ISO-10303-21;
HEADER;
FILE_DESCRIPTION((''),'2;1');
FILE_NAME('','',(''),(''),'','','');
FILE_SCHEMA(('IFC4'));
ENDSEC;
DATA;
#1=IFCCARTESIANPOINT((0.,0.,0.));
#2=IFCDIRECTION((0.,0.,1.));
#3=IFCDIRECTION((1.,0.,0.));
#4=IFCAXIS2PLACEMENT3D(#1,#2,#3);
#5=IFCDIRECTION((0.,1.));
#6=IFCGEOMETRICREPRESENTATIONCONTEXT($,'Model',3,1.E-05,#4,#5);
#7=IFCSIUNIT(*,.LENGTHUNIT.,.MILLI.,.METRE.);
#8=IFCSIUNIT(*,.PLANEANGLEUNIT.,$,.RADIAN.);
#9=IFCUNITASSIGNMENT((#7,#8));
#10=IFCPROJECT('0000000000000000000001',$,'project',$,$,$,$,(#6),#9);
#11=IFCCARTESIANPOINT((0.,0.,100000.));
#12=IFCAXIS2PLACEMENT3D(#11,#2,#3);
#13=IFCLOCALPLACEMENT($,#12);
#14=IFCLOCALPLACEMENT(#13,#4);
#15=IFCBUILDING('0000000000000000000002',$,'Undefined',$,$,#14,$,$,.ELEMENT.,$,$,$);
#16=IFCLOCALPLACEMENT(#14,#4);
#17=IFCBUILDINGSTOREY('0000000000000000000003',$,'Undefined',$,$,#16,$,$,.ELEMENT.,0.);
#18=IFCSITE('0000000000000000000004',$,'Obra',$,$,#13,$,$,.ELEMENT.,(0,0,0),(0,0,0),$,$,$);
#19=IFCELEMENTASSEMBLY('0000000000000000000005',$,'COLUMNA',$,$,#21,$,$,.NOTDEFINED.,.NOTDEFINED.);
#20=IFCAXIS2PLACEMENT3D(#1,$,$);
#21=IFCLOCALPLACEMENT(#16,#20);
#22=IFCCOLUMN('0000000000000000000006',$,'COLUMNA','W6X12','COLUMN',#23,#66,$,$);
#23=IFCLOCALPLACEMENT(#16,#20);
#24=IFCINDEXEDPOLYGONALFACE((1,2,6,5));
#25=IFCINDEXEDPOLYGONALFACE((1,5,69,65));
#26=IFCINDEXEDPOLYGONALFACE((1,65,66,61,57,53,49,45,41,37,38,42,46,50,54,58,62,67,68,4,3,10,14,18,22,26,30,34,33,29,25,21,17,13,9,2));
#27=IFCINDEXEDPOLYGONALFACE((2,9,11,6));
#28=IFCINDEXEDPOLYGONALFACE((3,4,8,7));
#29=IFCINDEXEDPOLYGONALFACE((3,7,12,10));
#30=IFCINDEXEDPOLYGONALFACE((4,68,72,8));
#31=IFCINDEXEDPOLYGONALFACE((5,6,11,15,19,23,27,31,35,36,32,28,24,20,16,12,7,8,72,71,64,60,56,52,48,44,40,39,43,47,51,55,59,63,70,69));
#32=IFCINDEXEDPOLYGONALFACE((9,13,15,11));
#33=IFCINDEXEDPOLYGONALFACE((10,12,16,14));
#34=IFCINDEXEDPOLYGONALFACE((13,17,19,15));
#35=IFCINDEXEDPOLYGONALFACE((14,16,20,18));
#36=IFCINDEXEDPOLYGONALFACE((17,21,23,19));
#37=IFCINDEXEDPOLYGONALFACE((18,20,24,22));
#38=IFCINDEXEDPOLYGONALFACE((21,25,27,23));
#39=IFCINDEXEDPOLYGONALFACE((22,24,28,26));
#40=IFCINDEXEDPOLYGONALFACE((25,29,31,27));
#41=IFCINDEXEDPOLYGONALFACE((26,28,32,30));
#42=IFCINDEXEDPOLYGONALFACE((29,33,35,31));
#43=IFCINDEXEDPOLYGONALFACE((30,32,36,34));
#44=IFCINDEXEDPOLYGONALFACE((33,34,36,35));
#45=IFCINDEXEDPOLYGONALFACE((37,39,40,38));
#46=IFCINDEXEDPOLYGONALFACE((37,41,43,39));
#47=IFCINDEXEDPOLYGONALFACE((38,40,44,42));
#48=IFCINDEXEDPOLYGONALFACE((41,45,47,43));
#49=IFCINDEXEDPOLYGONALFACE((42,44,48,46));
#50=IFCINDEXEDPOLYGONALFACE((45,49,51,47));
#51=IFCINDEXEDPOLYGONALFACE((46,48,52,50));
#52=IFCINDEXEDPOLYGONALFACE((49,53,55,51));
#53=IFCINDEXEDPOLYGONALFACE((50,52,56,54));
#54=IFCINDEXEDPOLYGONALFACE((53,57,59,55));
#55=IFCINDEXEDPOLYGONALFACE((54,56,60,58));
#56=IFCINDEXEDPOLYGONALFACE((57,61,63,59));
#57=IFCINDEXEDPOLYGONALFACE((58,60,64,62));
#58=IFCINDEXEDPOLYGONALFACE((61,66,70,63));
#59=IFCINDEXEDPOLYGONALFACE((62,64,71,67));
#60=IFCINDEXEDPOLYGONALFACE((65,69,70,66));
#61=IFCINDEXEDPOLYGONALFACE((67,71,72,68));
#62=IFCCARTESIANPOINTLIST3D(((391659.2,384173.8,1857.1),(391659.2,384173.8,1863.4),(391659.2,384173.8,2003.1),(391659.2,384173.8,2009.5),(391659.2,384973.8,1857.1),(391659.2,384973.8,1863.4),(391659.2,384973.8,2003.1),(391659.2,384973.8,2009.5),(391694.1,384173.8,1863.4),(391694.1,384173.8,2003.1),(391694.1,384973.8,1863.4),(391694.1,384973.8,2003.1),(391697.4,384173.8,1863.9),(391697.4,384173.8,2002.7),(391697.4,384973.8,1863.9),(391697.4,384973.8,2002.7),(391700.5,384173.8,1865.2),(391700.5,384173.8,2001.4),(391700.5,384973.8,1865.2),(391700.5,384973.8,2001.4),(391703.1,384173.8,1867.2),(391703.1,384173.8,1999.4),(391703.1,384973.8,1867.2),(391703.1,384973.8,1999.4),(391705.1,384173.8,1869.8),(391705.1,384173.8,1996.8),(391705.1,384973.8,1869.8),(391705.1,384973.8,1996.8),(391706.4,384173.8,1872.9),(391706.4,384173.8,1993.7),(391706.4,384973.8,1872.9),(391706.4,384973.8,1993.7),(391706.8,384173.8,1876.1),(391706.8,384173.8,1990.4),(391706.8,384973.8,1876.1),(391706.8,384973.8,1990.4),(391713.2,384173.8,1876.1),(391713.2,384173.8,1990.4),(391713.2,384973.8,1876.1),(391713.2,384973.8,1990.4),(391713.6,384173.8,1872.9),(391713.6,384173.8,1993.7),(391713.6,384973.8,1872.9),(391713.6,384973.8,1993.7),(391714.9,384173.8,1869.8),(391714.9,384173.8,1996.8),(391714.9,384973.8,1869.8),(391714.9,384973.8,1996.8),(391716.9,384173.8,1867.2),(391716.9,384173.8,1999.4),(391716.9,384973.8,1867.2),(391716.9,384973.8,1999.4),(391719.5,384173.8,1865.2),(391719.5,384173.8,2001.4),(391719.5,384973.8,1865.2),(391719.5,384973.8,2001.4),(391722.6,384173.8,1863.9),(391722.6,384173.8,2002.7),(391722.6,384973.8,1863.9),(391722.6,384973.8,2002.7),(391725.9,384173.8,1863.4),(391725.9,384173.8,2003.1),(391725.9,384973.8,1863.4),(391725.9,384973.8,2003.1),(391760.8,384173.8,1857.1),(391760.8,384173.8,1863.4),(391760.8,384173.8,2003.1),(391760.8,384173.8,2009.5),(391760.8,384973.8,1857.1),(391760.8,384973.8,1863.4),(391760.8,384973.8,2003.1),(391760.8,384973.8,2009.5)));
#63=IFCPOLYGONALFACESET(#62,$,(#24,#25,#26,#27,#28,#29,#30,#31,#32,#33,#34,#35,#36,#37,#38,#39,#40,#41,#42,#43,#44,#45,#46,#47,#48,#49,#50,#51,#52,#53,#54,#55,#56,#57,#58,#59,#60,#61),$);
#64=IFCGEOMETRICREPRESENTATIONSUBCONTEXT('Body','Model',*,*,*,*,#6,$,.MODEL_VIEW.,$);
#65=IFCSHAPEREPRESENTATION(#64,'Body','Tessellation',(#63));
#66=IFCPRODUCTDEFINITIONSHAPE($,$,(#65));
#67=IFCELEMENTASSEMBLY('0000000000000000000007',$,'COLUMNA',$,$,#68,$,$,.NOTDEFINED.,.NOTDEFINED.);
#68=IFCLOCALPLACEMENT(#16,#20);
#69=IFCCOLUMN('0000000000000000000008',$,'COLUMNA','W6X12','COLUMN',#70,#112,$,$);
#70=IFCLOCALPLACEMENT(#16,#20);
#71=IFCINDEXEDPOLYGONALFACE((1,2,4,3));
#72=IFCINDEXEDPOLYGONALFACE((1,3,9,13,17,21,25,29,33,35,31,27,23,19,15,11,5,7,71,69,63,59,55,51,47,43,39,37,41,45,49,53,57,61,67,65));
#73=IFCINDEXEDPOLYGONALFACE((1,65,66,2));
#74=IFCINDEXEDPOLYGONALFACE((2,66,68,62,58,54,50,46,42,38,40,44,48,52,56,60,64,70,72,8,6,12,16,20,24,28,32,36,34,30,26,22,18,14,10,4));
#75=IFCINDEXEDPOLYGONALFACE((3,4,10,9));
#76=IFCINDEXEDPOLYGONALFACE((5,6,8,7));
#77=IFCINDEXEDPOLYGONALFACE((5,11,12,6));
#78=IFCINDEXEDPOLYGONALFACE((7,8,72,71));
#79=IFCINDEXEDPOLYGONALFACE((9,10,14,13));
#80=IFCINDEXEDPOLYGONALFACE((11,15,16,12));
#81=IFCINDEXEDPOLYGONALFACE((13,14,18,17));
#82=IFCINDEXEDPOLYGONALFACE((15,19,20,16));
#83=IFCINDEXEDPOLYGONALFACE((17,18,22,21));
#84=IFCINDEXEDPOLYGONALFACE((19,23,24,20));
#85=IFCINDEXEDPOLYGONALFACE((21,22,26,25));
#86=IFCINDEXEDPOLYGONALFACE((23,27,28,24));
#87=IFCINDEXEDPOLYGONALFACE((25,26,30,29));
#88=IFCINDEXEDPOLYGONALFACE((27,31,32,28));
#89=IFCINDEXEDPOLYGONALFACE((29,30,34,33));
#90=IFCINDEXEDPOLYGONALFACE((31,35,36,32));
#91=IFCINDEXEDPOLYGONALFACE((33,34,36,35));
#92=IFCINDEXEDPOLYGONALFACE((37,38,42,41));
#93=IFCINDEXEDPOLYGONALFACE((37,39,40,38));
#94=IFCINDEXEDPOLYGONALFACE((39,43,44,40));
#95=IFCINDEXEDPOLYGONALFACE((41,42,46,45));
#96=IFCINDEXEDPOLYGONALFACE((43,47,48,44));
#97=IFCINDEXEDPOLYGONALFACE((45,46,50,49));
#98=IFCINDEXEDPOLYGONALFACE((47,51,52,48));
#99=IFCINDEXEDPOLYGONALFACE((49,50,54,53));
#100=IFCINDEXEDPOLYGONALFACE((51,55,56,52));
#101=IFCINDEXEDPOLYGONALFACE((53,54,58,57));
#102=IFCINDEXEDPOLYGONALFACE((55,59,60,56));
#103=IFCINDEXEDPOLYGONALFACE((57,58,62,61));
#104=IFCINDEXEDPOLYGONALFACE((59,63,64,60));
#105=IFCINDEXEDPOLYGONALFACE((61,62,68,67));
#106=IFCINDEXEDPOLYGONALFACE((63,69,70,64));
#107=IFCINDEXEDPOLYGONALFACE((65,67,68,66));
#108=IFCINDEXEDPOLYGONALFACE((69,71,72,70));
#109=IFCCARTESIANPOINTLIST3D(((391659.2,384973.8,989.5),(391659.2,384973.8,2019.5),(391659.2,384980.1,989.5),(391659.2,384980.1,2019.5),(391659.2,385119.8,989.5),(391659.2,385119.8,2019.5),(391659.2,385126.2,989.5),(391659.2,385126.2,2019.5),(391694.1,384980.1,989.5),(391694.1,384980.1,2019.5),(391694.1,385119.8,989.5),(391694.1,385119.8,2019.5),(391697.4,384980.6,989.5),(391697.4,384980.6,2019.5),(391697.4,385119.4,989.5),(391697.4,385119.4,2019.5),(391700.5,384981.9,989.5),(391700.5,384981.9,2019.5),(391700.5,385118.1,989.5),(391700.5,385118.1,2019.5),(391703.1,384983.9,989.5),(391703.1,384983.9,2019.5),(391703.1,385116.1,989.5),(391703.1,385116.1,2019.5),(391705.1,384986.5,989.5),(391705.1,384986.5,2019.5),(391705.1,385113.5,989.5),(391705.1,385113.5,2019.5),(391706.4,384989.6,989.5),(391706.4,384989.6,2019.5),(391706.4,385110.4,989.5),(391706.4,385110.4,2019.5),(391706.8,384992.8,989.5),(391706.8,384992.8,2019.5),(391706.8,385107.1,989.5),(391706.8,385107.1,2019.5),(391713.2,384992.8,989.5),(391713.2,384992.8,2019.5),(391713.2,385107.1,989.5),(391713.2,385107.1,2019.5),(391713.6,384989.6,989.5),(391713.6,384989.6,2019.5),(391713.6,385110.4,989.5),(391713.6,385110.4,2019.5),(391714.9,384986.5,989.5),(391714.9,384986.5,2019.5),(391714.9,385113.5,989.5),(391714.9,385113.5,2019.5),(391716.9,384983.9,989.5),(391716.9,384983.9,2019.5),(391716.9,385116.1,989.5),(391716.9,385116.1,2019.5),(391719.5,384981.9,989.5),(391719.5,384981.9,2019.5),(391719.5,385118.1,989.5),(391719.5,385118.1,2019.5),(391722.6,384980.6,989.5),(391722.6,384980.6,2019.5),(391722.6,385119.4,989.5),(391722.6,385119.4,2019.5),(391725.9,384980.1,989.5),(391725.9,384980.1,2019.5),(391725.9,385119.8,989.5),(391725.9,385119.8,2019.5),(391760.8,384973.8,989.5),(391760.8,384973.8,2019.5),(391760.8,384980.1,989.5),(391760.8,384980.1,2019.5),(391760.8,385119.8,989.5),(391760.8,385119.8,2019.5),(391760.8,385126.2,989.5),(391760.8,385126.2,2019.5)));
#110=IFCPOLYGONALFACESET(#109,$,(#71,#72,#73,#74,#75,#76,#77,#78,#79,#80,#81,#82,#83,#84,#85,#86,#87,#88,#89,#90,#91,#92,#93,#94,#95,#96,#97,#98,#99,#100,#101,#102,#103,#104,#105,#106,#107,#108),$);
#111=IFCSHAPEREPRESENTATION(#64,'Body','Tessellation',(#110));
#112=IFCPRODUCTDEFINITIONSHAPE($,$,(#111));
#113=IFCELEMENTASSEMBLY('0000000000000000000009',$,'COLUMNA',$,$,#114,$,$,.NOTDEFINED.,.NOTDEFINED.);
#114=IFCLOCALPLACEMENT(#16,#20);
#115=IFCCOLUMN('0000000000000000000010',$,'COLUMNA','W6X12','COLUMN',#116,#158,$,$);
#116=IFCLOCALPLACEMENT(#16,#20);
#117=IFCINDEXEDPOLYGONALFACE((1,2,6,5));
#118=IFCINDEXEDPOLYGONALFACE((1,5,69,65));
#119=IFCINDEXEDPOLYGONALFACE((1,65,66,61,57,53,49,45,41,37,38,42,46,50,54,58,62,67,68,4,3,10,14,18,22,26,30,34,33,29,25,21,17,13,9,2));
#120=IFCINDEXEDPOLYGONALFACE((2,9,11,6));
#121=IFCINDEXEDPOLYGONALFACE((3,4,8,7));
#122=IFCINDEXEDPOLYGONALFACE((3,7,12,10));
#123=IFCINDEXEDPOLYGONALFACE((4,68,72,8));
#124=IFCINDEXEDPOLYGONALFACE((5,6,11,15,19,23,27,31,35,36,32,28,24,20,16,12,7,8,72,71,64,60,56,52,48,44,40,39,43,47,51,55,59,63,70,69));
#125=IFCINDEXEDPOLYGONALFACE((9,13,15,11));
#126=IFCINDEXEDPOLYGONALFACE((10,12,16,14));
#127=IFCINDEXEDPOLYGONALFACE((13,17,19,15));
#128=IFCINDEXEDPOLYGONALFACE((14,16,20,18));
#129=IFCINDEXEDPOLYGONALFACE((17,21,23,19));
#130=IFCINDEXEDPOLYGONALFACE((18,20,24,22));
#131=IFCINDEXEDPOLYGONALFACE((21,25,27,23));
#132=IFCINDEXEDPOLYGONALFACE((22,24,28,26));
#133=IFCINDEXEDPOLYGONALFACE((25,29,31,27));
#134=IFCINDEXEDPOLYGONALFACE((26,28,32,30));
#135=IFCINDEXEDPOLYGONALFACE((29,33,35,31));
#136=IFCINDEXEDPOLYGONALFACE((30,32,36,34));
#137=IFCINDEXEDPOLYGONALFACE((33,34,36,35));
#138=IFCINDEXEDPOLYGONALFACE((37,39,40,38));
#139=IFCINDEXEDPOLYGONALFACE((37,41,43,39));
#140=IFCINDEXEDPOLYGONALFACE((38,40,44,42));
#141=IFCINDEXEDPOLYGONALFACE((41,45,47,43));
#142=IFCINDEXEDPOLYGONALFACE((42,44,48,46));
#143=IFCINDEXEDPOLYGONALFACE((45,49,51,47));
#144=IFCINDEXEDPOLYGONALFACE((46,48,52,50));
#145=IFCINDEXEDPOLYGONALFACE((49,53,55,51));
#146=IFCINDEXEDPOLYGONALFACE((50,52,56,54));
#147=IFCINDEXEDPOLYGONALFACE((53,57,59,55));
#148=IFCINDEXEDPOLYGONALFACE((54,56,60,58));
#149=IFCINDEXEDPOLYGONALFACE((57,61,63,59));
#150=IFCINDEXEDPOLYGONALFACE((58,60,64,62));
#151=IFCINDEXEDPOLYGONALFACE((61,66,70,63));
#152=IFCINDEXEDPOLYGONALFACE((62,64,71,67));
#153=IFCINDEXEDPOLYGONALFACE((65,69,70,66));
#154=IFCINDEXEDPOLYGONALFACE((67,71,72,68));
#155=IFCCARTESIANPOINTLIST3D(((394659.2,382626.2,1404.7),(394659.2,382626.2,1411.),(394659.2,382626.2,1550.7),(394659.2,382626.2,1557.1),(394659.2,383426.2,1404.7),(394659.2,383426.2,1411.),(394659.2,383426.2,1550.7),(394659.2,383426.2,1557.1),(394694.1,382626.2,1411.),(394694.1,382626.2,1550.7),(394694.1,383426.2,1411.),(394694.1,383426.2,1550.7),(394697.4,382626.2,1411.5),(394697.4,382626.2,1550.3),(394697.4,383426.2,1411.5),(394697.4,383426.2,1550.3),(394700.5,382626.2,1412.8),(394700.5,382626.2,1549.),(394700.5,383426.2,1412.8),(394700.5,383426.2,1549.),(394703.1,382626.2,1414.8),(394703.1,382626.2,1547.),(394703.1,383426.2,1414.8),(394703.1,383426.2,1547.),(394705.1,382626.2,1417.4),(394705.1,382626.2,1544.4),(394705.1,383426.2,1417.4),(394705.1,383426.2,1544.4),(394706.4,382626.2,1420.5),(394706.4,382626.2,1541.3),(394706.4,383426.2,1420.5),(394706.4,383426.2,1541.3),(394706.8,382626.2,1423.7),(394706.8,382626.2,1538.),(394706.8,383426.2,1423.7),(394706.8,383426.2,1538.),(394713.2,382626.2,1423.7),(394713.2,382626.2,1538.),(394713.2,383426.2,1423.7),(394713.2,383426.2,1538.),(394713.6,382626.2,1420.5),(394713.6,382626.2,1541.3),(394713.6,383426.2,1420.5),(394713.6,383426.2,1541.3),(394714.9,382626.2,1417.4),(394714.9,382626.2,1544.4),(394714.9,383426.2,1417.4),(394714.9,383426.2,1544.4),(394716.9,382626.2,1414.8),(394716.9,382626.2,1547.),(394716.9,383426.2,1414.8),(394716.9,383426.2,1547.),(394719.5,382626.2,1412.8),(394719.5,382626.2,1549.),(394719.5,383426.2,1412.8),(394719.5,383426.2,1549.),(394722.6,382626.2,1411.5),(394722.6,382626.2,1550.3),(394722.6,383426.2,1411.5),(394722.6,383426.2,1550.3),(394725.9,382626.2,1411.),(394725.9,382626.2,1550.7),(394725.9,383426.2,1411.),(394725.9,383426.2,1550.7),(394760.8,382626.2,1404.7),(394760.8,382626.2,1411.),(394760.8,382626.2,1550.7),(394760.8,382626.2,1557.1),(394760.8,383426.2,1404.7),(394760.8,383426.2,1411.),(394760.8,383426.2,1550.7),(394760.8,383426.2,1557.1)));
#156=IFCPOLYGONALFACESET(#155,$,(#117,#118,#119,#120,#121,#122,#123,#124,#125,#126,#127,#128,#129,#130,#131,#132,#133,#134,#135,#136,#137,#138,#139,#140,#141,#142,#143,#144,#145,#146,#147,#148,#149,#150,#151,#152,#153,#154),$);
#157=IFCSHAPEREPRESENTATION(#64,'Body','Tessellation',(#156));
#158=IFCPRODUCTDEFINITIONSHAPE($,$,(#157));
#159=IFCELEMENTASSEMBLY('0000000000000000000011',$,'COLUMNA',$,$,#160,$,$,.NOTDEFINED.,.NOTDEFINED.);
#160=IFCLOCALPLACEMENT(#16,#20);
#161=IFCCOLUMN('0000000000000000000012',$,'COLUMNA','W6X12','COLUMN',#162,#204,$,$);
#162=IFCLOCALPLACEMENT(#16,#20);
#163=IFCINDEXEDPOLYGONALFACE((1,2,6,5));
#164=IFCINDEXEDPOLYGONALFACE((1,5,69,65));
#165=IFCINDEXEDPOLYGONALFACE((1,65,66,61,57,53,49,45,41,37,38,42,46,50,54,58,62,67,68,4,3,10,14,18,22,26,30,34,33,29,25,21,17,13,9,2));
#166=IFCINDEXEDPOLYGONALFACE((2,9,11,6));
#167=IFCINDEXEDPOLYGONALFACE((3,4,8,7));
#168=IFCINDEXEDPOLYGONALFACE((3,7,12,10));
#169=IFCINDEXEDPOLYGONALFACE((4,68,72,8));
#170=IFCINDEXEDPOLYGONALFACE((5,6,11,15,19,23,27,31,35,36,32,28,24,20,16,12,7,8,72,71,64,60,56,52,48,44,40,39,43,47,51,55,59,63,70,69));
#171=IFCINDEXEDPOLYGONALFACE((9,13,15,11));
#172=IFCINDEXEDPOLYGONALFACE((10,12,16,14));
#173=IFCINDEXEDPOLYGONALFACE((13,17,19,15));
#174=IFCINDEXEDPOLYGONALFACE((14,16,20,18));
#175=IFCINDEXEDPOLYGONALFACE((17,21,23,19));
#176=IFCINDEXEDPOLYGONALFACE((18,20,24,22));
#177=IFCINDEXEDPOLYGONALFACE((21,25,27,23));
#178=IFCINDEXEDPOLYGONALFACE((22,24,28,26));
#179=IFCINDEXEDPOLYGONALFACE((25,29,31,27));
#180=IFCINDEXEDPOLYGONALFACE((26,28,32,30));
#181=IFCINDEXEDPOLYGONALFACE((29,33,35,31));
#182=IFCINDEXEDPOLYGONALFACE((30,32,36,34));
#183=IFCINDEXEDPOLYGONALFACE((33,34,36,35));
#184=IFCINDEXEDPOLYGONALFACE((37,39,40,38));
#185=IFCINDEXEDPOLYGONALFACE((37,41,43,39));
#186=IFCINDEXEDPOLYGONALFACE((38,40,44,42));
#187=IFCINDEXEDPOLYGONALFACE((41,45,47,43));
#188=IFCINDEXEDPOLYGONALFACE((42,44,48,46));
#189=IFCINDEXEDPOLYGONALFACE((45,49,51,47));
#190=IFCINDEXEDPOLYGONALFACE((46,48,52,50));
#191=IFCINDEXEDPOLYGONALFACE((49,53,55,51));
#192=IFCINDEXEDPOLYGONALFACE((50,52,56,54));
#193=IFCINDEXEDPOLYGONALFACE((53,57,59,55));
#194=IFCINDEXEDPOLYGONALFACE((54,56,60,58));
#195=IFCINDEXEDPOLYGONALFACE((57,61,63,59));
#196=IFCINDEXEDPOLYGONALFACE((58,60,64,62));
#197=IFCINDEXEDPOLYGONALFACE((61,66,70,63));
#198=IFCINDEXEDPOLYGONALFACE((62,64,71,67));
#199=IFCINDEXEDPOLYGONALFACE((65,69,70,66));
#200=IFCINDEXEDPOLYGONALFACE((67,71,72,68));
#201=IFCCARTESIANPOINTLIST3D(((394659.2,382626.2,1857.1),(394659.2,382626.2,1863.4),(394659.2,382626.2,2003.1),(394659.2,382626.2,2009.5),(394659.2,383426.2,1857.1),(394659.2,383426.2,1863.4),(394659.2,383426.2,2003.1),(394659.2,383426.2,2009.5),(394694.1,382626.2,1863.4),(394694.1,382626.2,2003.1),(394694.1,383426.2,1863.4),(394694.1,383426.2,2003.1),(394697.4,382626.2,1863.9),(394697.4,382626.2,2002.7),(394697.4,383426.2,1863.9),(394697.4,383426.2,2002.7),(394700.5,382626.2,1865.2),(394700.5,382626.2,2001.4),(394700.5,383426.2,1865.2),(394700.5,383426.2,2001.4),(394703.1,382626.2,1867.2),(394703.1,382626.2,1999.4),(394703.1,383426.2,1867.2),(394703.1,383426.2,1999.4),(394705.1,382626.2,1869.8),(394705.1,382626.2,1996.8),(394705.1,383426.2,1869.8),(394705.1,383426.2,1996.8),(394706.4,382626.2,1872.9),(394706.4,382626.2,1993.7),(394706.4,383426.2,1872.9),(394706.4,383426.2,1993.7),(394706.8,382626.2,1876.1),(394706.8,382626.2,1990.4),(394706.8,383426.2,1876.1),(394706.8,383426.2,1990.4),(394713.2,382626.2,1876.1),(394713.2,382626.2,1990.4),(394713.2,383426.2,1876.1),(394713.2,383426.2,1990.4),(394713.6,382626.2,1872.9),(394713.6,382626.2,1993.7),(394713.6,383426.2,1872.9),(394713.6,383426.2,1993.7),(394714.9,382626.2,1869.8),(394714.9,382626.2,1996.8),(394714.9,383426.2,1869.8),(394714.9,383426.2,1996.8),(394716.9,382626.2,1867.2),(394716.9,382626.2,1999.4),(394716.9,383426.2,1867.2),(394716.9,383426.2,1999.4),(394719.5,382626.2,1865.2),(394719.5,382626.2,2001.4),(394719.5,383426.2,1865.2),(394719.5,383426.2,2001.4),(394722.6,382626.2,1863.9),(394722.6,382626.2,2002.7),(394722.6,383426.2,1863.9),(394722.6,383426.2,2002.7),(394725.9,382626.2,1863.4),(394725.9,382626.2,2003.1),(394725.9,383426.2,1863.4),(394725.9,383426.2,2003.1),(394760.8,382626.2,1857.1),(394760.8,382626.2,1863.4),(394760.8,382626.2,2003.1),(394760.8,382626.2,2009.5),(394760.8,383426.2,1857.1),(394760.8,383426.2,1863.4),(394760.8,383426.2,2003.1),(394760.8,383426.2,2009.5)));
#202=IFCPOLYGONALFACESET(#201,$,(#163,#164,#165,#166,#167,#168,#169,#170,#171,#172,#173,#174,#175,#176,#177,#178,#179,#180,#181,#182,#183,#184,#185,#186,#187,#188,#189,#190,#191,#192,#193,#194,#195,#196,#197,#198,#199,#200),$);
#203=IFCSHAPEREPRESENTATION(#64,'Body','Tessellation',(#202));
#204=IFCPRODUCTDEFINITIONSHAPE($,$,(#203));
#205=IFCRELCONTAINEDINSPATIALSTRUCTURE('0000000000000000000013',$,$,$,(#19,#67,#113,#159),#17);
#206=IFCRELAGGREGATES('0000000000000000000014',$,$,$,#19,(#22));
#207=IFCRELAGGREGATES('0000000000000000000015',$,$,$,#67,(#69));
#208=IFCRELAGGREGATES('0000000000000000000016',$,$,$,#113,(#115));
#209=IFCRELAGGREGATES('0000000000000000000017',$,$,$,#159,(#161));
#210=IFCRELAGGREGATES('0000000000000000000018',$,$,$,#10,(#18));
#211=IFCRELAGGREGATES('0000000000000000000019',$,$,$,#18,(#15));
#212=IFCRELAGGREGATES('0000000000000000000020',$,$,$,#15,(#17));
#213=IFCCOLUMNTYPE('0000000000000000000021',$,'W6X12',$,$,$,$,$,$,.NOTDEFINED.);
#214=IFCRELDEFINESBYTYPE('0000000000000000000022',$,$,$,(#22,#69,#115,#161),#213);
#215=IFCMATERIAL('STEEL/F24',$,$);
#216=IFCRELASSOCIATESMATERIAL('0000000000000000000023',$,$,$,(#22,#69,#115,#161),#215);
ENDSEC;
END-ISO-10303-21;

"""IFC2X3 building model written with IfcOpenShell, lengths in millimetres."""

from ifc_helpers import new_model, si_unit, direction, frame, origin_with_axes, origin_2d_with_axis, place, context, subcontext, project, spatial, i_section, extrude, material, type_object, element, aggregate, save


model = new_model("IFC2X3")

# Units and contexts
model_context = context("Model", 3, precision=1e-05, world=origin_with_axes(), true_north=direction((0.0, 1.0)))
body_context = subcontext(model_context, "Body", "Model", "MODEL_VIEW")
ifc_project = project(units=[si_unit("LENGTHUNIT", "METRE", prefix="MILLI"), si_unit("PLANEANGLEUNIT", "RADIAN")], contexts=[model_context])

# Site, building, storey
site_placement = place(None, frame((0.0, 0.0, 100000.0), z_axis=(0.0, 0.0, 1.0), x_axis=(1.0, 0.0, 0.0)))
site = spatial("IfcSite", under=ifc_project, at=site_placement, Name="Obra", CompositionType="ELEMENT", RefLatitude=(0, 0, 0), RefLongitude=(0, 0, 0))
building_placement = place(site_placement, origin_with_axes())
building = spatial("IfcBuilding", under=site, at=building_placement, Name="Undefined", CompositionType="ELEMENT")
storey_placement = place(building_placement, origin_with_axes())
storey = spatial("IfcBuildingStorey", under=building, at=storey_placement, Name="Undefined", CompositionType="ELEMENT", Elevation=0.0)

# Element assemblies, columns
ifc_material_1 = material(Name="STEEL/F24")
column_type_1 = type_object("IfcColumnType", Name="W6X12", PredefinedType="NOTDEFINED")
assembly_1_placement = place(storey_placement, origin_with_axes())
assembly_1 = element("IfcElementAssembly", 1, at=assembly_1_placement, inside=storey, Name="COLUMNA", AssemblyPlace="NOTDEFINED", PredefinedType="NOTDEFINED")
column_1_placement = place(assembly_1_placement, frame((391710.0, 384973.8, 1933.3), z_axis=(0.0, -1.0, 0.0), x_axis=(0.0, 0.0, -1.0)))
column_1 = element("IfcColumn", 2, at=column_1_placement, type_object=column_type_1, material=ifc_material_1, Name="COLUMNA", Description="W6X12", ObjectType="COLUMN", context=body_context, shape_type="SweptSolid", body=[
    extrude(i_section(OverallWidth=101.6, OverallDepth=152.4, WebThickness=6.3, FlangeThickness=6.3, FilletRadius=12.7, at=origin_2d_with_axis()), frame((0.0, 0.0, 800.0), z_axis=(0.0, 0.0, -1.0), x_axis=(0.0, 1.0, 0.0)), (0.0, 0.0, 1.0), 800.0),
])
aggregate(assembly_1, [column_1])
assembly_2_placement = place(storey_placement, origin_with_axes())
assembly_2 = element("IfcElementAssembly", 3, at=assembly_2_placement, inside=storey, Name="COLUMNA", AssemblyPlace="NOTDEFINED", PredefinedType="NOTDEFINED")
column_2_placement = place(assembly_2_placement, frame((391710.0, 385050.0, 989.5), z_axis=(0.0, 0.0, 1.0), x_axis=(0.0, 1.0, 0.0)))
column_2 = element("IfcColumn", 4, at=column_2_placement, type_object=column_type_1, material=ifc_material_1, Name="COLUMNA", Description="W6X12", ObjectType="COLUMN", context=body_context, shape_type="SweptSolid", body=[
    extrude(i_section(OverallWidth=101.6, OverallDepth=152.4, WebThickness=6.3, FlangeThickness=6.3, FilletRadius=12.7, at=origin_2d_with_axis()), frame((0.0, 0.0, 1030.0), z_axis=(0.0, 0.0, -1.0), x_axis=(0.0, 1.0, 0.0)), (0.0, 0.0, 1.0), 1030.0),
])
aggregate(assembly_2, [column_2])
assembly_3_placement = place(storey_placement, origin_with_axes())
assembly_3 = element("IfcElementAssembly", 5, at=assembly_3_placement, inside=storey, Name="COLUMNA", AssemblyPlace="NOTDEFINED", PredefinedType="NOTDEFINED")
column_3_placement = place(assembly_3_placement, frame((394710.0, 382626.2, 1480.9), z_axis=(0.0, 1.0, 0.0), x_axis=(0.0, 0.0, -1.0)))
column_3 = element("IfcColumn", 6, at=column_3_placement, type_object=column_type_1, material=ifc_material_1, Name="COLUMNA", Description="W6X12", ObjectType="COLUMN", context=body_context, shape_type="SweptSolid", body=[
    extrude(i_section(OverallWidth=101.6, OverallDepth=152.4, WebThickness=6.3, FlangeThickness=6.3, FilletRadius=12.7, at=origin_2d_with_axis()), frame((0.0, 0.0, 800.0), z_axis=(0.0, 0.0, -1.0), x_axis=(0.0, 1.0, 0.0)), (0.0, 0.0, 1.0), 800.0),
])
aggregate(assembly_3, [column_3])
assembly_4_placement = place(storey_placement, origin_with_axes())
assembly_4 = element("IfcElementAssembly", 7, at=assembly_4_placement, inside=storey, Name="COLUMNA", AssemblyPlace="NOTDEFINED", PredefinedType="NOTDEFINED")
column_4_placement = place(assembly_4_placement, frame((394710.0, 382626.2, 1933.3), z_axis=(0.0, 1.0, 0.0), x_axis=(0.0, 0.0, -1.0)))
column_4 = element("IfcColumn", 8, at=column_4_placement, type_object=column_type_1, material=ifc_material_1, Name="COLUMNA", Description="W6X12", ObjectType="COLUMN", context=body_context, shape_type="SweptSolid", body=[
    extrude(i_section(OverallWidth=101.6, OverallDepth=152.4, WebThickness=6.3, FlangeThickness=6.3, FilletRadius=12.7, at=origin_2d_with_axis()), frame((0.0, 0.0, 800.0), z_axis=(0.0, 0.0, -1.0), x_axis=(0.0, 1.0, 0.0)), (0.0, 0.0, 1.0), 800.0),
])
aggregate(assembly_4, [column_4])

save(model, "model.ifc")
